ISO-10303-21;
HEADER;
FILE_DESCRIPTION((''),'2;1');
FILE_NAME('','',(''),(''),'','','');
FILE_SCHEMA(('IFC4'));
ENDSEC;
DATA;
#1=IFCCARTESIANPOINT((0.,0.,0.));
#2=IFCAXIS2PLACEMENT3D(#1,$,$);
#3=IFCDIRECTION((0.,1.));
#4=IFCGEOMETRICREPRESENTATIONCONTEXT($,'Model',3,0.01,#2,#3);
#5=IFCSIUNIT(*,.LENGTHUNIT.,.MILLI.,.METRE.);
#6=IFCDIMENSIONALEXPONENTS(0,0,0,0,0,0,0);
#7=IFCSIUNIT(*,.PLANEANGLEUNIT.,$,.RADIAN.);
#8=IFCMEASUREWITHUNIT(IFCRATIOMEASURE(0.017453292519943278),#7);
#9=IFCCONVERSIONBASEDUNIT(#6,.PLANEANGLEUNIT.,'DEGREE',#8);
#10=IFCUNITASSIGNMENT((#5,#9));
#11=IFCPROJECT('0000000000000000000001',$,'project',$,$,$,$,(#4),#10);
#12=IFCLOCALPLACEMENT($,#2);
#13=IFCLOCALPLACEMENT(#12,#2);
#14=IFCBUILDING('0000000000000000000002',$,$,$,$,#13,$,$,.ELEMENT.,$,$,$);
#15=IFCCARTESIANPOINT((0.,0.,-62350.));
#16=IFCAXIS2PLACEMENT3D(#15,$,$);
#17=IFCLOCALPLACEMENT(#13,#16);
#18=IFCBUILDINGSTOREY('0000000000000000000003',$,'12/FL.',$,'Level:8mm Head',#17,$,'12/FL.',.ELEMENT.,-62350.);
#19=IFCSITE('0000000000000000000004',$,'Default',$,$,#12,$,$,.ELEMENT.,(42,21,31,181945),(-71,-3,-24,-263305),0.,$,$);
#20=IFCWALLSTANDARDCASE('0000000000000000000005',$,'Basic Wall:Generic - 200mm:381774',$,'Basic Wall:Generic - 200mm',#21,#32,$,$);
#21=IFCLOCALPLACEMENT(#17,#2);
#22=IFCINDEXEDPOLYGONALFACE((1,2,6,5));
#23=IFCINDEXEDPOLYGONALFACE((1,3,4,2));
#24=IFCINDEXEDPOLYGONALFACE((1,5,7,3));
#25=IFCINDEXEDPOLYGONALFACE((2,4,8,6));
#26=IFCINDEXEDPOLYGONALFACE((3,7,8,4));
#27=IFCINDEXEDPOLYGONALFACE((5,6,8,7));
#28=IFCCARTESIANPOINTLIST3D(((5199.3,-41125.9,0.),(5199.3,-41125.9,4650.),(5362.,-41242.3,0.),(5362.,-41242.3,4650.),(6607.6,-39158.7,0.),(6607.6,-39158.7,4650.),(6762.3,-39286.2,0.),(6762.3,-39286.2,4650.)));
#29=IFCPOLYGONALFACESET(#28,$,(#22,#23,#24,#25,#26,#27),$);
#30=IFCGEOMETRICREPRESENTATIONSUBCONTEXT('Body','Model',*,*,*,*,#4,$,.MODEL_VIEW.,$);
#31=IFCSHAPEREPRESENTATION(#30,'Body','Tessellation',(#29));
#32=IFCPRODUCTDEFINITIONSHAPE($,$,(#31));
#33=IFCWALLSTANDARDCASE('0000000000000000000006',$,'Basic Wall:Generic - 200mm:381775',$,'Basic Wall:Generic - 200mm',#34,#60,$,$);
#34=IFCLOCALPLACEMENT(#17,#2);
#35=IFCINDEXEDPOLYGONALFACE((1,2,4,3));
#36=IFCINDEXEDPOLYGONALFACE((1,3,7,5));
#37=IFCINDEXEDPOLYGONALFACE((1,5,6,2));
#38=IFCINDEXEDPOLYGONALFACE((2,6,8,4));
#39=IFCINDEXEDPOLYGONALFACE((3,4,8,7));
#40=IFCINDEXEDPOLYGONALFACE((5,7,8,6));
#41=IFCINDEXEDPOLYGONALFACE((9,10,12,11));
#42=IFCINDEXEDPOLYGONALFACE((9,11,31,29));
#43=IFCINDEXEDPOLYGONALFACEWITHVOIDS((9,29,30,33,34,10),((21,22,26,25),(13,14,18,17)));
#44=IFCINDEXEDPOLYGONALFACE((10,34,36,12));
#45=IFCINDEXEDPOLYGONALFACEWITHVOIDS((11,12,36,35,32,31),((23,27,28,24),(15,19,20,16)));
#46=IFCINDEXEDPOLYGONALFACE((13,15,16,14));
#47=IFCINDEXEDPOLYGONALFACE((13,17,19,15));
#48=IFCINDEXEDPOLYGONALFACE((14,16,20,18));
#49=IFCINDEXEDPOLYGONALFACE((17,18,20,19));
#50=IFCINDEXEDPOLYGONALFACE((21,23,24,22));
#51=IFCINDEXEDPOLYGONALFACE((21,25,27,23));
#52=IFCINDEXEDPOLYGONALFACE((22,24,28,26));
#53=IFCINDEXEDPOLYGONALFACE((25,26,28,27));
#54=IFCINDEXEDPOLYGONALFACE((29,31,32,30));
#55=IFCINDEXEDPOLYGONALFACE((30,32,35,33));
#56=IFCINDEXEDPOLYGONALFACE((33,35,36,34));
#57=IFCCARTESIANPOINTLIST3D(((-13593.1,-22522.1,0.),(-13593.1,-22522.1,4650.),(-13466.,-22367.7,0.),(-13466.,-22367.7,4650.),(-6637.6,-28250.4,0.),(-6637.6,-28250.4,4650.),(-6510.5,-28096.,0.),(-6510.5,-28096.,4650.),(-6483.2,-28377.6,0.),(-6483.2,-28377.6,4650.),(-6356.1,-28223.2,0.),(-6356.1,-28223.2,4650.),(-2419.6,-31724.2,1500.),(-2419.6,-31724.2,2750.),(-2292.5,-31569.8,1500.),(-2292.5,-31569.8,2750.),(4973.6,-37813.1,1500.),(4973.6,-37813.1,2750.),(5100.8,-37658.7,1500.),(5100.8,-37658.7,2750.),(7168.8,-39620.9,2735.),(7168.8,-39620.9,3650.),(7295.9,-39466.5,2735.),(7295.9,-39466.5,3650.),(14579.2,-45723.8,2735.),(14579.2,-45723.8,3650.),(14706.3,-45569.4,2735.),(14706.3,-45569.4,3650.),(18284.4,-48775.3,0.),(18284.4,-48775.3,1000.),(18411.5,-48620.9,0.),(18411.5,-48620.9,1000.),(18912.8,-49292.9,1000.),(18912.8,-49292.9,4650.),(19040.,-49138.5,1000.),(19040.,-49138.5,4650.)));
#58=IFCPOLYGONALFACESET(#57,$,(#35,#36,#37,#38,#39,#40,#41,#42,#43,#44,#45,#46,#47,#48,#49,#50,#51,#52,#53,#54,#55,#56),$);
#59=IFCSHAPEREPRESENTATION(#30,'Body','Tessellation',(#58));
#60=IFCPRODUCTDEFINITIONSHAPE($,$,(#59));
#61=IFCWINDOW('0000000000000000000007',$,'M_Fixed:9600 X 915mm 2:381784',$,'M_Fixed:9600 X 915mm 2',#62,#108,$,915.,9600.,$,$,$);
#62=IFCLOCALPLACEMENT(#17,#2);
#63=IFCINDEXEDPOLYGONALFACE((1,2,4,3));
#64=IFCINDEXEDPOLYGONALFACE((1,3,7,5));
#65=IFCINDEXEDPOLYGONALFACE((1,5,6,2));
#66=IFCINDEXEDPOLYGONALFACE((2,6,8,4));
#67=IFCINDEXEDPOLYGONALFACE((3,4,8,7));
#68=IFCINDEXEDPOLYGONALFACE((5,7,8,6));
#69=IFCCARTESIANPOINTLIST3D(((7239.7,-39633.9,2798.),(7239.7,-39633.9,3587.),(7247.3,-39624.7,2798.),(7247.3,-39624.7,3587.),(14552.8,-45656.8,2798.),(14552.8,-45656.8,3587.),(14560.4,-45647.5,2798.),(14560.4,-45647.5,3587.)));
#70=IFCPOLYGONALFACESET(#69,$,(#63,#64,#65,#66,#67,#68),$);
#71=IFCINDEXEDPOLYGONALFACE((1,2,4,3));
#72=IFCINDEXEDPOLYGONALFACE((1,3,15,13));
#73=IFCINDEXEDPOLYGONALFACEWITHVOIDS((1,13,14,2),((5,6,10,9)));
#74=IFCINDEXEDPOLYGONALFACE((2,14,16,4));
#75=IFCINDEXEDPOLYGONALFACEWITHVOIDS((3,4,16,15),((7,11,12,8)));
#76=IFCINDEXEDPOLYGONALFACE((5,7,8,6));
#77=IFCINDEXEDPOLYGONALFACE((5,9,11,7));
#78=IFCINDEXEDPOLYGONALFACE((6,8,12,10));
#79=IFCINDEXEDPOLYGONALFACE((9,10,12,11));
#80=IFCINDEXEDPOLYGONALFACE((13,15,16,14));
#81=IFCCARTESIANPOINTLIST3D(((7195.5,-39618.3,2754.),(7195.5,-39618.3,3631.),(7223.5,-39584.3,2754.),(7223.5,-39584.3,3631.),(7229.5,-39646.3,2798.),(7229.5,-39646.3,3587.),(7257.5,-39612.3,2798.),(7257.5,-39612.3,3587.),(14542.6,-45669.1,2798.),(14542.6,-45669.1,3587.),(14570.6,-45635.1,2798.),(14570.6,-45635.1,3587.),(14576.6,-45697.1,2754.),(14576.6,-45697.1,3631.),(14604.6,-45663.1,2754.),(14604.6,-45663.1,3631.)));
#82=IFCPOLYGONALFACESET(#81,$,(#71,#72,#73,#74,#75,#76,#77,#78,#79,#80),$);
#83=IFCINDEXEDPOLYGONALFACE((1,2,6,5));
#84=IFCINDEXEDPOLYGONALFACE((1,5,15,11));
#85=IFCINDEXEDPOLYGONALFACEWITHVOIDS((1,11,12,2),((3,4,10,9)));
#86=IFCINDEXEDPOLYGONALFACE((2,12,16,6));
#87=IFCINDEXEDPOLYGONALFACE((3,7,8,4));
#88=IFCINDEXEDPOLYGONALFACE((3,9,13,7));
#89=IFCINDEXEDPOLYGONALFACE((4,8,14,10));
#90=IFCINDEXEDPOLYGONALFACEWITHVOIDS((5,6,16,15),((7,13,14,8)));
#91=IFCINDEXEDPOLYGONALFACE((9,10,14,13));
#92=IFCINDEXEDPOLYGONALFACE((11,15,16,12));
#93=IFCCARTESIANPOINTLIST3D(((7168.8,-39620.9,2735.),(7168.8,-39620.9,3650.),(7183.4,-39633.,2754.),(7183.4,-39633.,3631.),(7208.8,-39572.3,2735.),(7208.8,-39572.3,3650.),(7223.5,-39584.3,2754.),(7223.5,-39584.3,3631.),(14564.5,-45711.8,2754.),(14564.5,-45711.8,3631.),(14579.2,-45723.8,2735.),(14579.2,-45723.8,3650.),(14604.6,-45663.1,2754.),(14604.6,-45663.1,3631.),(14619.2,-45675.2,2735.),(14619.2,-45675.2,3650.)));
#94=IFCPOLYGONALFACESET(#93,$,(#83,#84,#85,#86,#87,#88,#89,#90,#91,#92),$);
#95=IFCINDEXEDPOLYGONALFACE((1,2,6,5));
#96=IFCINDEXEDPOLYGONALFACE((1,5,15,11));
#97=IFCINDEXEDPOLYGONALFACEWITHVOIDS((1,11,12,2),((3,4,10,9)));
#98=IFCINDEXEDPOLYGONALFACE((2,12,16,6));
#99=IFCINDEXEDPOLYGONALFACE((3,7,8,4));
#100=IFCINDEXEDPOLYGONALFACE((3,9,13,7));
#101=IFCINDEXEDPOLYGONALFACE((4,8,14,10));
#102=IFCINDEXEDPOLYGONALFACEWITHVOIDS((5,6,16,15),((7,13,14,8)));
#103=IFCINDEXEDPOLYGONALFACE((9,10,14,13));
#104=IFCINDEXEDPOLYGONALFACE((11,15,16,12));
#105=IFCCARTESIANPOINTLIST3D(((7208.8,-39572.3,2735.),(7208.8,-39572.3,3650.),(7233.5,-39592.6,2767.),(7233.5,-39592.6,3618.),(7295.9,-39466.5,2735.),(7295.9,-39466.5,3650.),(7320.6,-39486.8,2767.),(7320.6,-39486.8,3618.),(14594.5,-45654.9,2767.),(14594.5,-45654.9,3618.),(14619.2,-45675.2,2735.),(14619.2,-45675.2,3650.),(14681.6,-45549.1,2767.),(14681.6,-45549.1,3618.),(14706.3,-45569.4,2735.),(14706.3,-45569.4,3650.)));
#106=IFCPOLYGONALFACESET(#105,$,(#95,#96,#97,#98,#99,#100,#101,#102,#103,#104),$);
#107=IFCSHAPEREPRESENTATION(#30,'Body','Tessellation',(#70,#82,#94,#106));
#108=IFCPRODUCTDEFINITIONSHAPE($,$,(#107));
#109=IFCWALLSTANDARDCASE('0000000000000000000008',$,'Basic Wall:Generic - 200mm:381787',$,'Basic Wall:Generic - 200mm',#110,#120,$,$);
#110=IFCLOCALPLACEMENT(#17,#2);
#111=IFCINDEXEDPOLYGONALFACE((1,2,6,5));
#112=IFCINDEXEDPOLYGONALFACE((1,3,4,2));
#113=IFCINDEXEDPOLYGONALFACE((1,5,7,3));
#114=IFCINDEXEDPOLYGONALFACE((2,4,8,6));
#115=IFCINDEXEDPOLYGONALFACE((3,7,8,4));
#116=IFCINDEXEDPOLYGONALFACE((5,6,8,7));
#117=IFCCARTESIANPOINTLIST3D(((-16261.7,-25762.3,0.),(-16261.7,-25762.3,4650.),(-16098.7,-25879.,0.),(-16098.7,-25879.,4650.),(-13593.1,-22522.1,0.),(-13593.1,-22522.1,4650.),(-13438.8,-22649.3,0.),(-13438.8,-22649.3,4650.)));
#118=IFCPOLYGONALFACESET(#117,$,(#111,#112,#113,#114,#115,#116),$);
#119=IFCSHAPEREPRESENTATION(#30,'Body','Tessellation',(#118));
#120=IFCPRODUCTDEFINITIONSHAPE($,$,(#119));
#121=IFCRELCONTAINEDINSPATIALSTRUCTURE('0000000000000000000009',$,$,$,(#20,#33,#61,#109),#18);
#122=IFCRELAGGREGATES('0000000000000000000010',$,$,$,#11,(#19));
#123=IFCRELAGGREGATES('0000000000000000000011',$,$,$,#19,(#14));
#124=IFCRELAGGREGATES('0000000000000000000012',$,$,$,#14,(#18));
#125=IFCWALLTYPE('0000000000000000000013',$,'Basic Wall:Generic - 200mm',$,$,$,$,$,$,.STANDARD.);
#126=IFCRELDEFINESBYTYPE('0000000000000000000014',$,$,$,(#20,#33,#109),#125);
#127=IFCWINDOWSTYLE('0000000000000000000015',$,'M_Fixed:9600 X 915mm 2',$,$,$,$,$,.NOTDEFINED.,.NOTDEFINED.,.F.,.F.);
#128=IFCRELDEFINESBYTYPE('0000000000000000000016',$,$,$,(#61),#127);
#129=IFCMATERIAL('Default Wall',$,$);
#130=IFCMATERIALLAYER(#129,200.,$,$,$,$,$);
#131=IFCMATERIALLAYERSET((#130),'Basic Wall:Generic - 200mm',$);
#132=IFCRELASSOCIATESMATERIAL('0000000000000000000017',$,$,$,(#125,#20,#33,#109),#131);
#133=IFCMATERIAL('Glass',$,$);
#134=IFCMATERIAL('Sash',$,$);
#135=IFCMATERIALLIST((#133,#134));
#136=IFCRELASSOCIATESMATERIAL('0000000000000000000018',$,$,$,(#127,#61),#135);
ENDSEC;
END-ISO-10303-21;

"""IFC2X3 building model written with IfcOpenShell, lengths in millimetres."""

from ifc_helpers import new_model, entity, si_unit, converted_unit, direction, frame, frame_2d, origin, place, context, subcontext, project, spatial, polyline, rectangle, outline, extrude, source, transform, mapped, material, material_list, layer, layer_set, layer_usage, type_object, type_shapes, element, fill, save


model = new_model("IFC2X3")

# Units and contexts
model_context = context("Model", 3, precision=0.01, world=origin(), true_north=direction((0.0, 1.0)))
body_context = subcontext(model_context, "Body", "Model", "MODEL_VIEW")
ifc_project = project(units=[si_unit("LENGTHUNIT", "METRE", prefix="MILLI"), converted_unit("PLANEANGLEUNIT", "DEGREE", entity("IfcRatioMeasure", 0.017453292519943278), si_unit("PLANEANGLEUNIT", "RADIAN"), dimensions=[0, 0, 0, 0, 0, 0, 0])], contexts=[model_context])

# Site, building, storey
site_placement = place(None, origin())
site = spatial("IfcSite", under=ifc_project, at=site_placement, Name="Default", CompositionType="ELEMENT", RefLatitude=(42, 21, 31, 181945), RefLongitude=(-71, -3, -24, -263305), RefElevation=0.0)
building_placement = place(site_placement, origin())
building = spatial("IfcBuilding", under=site, at=building_placement, CompositionType="ELEMENT")
storey_placement = place(building_placement, frame((0.0, 0.0, -62350.0)))
storey = spatial("IfcBuildingStorey", under=building, at=storey_placement, Name="12/FL.", ObjectType="Level:8mm Head", LongName="12/FL.", CompositionType="ELEMENT", Elevation=-62350.0)

# Shared definitions
ifc_material_1 = material(Name="Default Wall")
ifc_layer = layer(ifc_material_1, 200.0)
ifc_layer_set = layer_set([ifc_layer], Name="Basic Wall:Generic - 200mm")
ifc_layer_usage = layer_usage(ifc_layer_set, "AXIS2", "NEGATIVE", 100.0)
wall_type = type_object("IfcWallType", Name="Basic Wall:Generic - 200mm", PredefinedType="STANDARD", material=ifc_layer_set)

# Shared definitions
ifc_material_2 = material(Name="Glass")
ifc_material_3 = material(Name="Sash")
ifc_material_list = material_list([ifc_material_2, ifc_material_3])

# Wall
wall_1_placement = place(storey_placement, frame((5280.7, -41184.1, 0.0), z_axis=(0.0, 0.0, 1.0), x_axis=(0.582098, 0.813119, 0.0)))
element("IfcWallStandardCase", 1, at=wall_1_placement, inside=storey, type_object=wall_type, material=ifc_layer_usage, Name="Basic Wall:Generic - 200mm:381774", ObjectType="Basic Wall:Generic - 200mm", context=body_context, shape_type="SweptSolid", body=[
    extrude(outline(polyline([(2405.7, -100.0), (2419.3, 100.0), (0.0, 100.0), (0.0, -100.0), (2405.7, -100.0)])), origin(), (0.0, 0.0, 1.0), 4650.0),
])

# Wall, openings, window
wall_2_placement = place(storey_placement, frame((-13529.6, -22444.9, 0.0), z_axis=(0.0, 0.0, 1.0), x_axis=(0.771917, -0.635723, 0.0)))
wall_2 = element("IfcWallStandardCase", 2, at=wall_2_placement, inside=storey, type_object=wall_type, material=ifc_layer_usage, Name="Basic Wall:Generic - 200mm:381775", ObjectType="Basic Wall:Generic - 200mm", context=body_context, shape_type="SweptSolid", body=[
    extrude(rectangle(XDim=42110.7, YDim=200.0, at=frame_2d((21055.3, 0.0), x_axis=(-1.0, 0.0))), origin(), (0.0, 0.0, 1.0), 4650.0),
])
opening_1_placement = place(storey_placement, frame((-13529.6, -22444.9, 0.0), z_axis=(0.0, 0.0, 1.0), x_axis=(0.771917, -0.635723, 0.0)))
element("IfcOpeningElement", 3, at=opening_1_placement, cuts=wall_2, ObjectType="Opening", context=body_context, shape_type="SweptSolid", body=[
    extrude(rectangle(XDim=4650.0, YDim=200.0, at=frame_2d((0.0, 0.0), x_axis=(1.0, 0.0))), frame((9210.7, 0.0, 2325.0), z_axis=(-1.0, 0.0, 0.0), x_axis=(0.0, 0.0, 1.0)), (0.0, 0.0, 1.0), 200.0),
])
opening_2_placement = place(wall_2_placement, origin())
element("IfcOpeningElement", 4, at=opening_2_placement, cuts=wall_2, ObjectType="Opening", context=body_context, shape_type="SweptSolid", body=[
    extrude(rectangle(XDim=1250.0, YDim=9577.8, at=frame_2d((0.0, 0.0), x_axis=(1.0, 0.0))), frame((19263.9, -100.0, 2125.0), z_axis=(0.0, 1.0, 0.0), x_axis=(0.0, 0.0, -1.0)), (0.0, 0.0, 1.0), 200.0),
])
opening_3_placement = place(wall_2_placement, frame((-3825.1, 25926.7, 0.0), z_axis=(0.0, 0.0, 1.0), x_axis=(0.771917, 0.635723, 0.0)))
element("IfcOpeningElement", 5, at=opening_3_placement, cuts=wall_2, ObjectType="Opening", context=body_context, shape_type="SweptSolid", body=[
    extrude(rectangle(XDim=1000.0, YDim=1010.1, at=frame_2d((0.0, 0.0), x_axis=(1.0, 0.0))), frame((18666.2, -49106.2, 500.0), z_axis=(0.635723, 0.771917, 0.0), x_axis=(0.0, 0.0, -1.0)), (0.0, 0.0, 1.0), 1012.7),
])
opening_4_placement = place(wall_2_placement, frame((36496.6, 100.0, 2735.0)))
opening_4 = element("IfcOpeningElement", 6, at=opening_4_placement, cuts=wall_2, ObjectType="Opening", context=body_context, shape_type="SweptSolid", body=[
    extrude(rectangle(XDim=915.0, YDim=9600.0, at=frame_2d((457.5, 4800.0), x_axis=(1.0, 0.0))), frame((0.0, 0.0, 0.0), z_axis=(0.0, -1.0, 0.0), x_axis=(0.0, 0.0, 1.0)), (0.0, 0.0, 1.0), 200.0),
])
window_style_1 = type_object("IfcWindowStyle", Name="M_Fixed:9600 X 915mm 2", ConstructionType="NOTDEFINED", OperationType="NOTDEFINED", ParameterTakesPrecedence=False, Sizeable=False, material=ifc_material_list)
shared_shape_1 = source(origin(), body_context, "Body", "SweptSolid", [
    extrude(rectangle(XDim=12.0, YDim=9474.0, at=frame_2d((0.0, 0.0), x_axis=(1.0, 0.0))), frame((4800.0, 159.0, 63.0), z_axis=(0.0, 0.0, 1.0), x_axis=(0.0, -1.0, 0.0)), (0.0, 0.0, 1.0), 789.0),
    extrude(outline(polyline([(-4781.0, -438.5), (4781.0, -438.5), (4781.0, 438.5), (-4781.0, 438.5), (-4781.0, -438.5)]), holes=[polyline([(-4737.0, -394.5), (-4737.0, 394.5), (4737.0, 394.5), (4737.0, -394.5), (-4737.0, -394.5)])]), frame((4800.0, 137.0, 457.5), z_axis=(0.0, 1.0, 0.0), x_axis=(1.0, 0.0, 0.0)), (0.0, 0.0, 1.0), 44.0),
    extrude(outline(polyline([(-4800.0, -457.5), (4800.0, -457.5), (4800.0, 457.5), (-4800.0, 457.5), (-4800.0, -457.5)]), holes=[polyline([(-4781.0, -438.5), (-4781.0, 438.5), (4781.0, 438.5), (4781.0, -438.5), (-4781.0, -438.5)])]), frame((4800.0, 137.0, 457.5), z_axis=(0.0, 1.0, 0.0), x_axis=(1.0, 0.0, 0.0)), (0.0, 0.0, 1.0), 63.0),
    extrude(outline(polyline([(-4800.0, -457.5), (4800.0, -457.5), (4800.0, 457.5), (-4800.0, 457.5), (-4800.0, -457.5)]), holes=[polyline([(-4768.0, -425.5), (-4768.0, 425.5), (4768.0, 425.5), (4768.0, -425.5), (-4768.0, -425.5)])]), frame((4800.0, 0.0, 457.5), z_axis=(0.0, 1.0, 0.0), x_axis=(1.0, 0.0, 0.0)), (0.0, 0.0, 1.0), 137.0),
])
type_shapes(window_style_1, [shared_shape_1])
window_1_placement = place(opening_4_placement, frame((0.0, 0.0, 0.0), z_axis=(0.0, 0.0, 1.0), x_axis=(-1.0, 0.0, 0.0)))
window_1 = element("IfcWindow", 7, at=window_1_placement, inside=storey, type_object=window_style_1, material=ifc_material_list, Name="M_Fixed:9600 X 915mm 2:381784", ObjectType="M_Fixed:9600 X 915mm 2", OverallHeight=915.0, OverallWidth=9600.0, context=body_context, shape_type="MappedRepresentation", body=[
    mapped(shared_shape_1, transform((0.0, 0.0, 0.0), scale=1.0)),
])
fill(opening_4, window_1)

# Wall
wall_3_placement = place(storey_placement, frame((-16184.5, -25825.9, 0.0), z_axis=(0.0, 0.0, 1.0), x_axis=(0.635723, 0.771917, 0.0)))
element("IfcWallStandardCase", 8, at=wall_3_placement, inside=storey, type_object=wall_type, material=ifc_layer_usage, Name="Basic Wall:Generic - 200mm:381787", ObjectType="Basic Wall:Generic - 200mm", context=body_context, shape_type="SweptSolid", body=[
    extrude(outline(polyline([(4197.6, -100.0), (4197.6, 100.0), (0.0, 100.0), (13.5, -100.0), (4197.6, -100.0)])), origin(), (0.0, 0.0, 1.0), 4650.0),
])

save(model, "model.ifc")
